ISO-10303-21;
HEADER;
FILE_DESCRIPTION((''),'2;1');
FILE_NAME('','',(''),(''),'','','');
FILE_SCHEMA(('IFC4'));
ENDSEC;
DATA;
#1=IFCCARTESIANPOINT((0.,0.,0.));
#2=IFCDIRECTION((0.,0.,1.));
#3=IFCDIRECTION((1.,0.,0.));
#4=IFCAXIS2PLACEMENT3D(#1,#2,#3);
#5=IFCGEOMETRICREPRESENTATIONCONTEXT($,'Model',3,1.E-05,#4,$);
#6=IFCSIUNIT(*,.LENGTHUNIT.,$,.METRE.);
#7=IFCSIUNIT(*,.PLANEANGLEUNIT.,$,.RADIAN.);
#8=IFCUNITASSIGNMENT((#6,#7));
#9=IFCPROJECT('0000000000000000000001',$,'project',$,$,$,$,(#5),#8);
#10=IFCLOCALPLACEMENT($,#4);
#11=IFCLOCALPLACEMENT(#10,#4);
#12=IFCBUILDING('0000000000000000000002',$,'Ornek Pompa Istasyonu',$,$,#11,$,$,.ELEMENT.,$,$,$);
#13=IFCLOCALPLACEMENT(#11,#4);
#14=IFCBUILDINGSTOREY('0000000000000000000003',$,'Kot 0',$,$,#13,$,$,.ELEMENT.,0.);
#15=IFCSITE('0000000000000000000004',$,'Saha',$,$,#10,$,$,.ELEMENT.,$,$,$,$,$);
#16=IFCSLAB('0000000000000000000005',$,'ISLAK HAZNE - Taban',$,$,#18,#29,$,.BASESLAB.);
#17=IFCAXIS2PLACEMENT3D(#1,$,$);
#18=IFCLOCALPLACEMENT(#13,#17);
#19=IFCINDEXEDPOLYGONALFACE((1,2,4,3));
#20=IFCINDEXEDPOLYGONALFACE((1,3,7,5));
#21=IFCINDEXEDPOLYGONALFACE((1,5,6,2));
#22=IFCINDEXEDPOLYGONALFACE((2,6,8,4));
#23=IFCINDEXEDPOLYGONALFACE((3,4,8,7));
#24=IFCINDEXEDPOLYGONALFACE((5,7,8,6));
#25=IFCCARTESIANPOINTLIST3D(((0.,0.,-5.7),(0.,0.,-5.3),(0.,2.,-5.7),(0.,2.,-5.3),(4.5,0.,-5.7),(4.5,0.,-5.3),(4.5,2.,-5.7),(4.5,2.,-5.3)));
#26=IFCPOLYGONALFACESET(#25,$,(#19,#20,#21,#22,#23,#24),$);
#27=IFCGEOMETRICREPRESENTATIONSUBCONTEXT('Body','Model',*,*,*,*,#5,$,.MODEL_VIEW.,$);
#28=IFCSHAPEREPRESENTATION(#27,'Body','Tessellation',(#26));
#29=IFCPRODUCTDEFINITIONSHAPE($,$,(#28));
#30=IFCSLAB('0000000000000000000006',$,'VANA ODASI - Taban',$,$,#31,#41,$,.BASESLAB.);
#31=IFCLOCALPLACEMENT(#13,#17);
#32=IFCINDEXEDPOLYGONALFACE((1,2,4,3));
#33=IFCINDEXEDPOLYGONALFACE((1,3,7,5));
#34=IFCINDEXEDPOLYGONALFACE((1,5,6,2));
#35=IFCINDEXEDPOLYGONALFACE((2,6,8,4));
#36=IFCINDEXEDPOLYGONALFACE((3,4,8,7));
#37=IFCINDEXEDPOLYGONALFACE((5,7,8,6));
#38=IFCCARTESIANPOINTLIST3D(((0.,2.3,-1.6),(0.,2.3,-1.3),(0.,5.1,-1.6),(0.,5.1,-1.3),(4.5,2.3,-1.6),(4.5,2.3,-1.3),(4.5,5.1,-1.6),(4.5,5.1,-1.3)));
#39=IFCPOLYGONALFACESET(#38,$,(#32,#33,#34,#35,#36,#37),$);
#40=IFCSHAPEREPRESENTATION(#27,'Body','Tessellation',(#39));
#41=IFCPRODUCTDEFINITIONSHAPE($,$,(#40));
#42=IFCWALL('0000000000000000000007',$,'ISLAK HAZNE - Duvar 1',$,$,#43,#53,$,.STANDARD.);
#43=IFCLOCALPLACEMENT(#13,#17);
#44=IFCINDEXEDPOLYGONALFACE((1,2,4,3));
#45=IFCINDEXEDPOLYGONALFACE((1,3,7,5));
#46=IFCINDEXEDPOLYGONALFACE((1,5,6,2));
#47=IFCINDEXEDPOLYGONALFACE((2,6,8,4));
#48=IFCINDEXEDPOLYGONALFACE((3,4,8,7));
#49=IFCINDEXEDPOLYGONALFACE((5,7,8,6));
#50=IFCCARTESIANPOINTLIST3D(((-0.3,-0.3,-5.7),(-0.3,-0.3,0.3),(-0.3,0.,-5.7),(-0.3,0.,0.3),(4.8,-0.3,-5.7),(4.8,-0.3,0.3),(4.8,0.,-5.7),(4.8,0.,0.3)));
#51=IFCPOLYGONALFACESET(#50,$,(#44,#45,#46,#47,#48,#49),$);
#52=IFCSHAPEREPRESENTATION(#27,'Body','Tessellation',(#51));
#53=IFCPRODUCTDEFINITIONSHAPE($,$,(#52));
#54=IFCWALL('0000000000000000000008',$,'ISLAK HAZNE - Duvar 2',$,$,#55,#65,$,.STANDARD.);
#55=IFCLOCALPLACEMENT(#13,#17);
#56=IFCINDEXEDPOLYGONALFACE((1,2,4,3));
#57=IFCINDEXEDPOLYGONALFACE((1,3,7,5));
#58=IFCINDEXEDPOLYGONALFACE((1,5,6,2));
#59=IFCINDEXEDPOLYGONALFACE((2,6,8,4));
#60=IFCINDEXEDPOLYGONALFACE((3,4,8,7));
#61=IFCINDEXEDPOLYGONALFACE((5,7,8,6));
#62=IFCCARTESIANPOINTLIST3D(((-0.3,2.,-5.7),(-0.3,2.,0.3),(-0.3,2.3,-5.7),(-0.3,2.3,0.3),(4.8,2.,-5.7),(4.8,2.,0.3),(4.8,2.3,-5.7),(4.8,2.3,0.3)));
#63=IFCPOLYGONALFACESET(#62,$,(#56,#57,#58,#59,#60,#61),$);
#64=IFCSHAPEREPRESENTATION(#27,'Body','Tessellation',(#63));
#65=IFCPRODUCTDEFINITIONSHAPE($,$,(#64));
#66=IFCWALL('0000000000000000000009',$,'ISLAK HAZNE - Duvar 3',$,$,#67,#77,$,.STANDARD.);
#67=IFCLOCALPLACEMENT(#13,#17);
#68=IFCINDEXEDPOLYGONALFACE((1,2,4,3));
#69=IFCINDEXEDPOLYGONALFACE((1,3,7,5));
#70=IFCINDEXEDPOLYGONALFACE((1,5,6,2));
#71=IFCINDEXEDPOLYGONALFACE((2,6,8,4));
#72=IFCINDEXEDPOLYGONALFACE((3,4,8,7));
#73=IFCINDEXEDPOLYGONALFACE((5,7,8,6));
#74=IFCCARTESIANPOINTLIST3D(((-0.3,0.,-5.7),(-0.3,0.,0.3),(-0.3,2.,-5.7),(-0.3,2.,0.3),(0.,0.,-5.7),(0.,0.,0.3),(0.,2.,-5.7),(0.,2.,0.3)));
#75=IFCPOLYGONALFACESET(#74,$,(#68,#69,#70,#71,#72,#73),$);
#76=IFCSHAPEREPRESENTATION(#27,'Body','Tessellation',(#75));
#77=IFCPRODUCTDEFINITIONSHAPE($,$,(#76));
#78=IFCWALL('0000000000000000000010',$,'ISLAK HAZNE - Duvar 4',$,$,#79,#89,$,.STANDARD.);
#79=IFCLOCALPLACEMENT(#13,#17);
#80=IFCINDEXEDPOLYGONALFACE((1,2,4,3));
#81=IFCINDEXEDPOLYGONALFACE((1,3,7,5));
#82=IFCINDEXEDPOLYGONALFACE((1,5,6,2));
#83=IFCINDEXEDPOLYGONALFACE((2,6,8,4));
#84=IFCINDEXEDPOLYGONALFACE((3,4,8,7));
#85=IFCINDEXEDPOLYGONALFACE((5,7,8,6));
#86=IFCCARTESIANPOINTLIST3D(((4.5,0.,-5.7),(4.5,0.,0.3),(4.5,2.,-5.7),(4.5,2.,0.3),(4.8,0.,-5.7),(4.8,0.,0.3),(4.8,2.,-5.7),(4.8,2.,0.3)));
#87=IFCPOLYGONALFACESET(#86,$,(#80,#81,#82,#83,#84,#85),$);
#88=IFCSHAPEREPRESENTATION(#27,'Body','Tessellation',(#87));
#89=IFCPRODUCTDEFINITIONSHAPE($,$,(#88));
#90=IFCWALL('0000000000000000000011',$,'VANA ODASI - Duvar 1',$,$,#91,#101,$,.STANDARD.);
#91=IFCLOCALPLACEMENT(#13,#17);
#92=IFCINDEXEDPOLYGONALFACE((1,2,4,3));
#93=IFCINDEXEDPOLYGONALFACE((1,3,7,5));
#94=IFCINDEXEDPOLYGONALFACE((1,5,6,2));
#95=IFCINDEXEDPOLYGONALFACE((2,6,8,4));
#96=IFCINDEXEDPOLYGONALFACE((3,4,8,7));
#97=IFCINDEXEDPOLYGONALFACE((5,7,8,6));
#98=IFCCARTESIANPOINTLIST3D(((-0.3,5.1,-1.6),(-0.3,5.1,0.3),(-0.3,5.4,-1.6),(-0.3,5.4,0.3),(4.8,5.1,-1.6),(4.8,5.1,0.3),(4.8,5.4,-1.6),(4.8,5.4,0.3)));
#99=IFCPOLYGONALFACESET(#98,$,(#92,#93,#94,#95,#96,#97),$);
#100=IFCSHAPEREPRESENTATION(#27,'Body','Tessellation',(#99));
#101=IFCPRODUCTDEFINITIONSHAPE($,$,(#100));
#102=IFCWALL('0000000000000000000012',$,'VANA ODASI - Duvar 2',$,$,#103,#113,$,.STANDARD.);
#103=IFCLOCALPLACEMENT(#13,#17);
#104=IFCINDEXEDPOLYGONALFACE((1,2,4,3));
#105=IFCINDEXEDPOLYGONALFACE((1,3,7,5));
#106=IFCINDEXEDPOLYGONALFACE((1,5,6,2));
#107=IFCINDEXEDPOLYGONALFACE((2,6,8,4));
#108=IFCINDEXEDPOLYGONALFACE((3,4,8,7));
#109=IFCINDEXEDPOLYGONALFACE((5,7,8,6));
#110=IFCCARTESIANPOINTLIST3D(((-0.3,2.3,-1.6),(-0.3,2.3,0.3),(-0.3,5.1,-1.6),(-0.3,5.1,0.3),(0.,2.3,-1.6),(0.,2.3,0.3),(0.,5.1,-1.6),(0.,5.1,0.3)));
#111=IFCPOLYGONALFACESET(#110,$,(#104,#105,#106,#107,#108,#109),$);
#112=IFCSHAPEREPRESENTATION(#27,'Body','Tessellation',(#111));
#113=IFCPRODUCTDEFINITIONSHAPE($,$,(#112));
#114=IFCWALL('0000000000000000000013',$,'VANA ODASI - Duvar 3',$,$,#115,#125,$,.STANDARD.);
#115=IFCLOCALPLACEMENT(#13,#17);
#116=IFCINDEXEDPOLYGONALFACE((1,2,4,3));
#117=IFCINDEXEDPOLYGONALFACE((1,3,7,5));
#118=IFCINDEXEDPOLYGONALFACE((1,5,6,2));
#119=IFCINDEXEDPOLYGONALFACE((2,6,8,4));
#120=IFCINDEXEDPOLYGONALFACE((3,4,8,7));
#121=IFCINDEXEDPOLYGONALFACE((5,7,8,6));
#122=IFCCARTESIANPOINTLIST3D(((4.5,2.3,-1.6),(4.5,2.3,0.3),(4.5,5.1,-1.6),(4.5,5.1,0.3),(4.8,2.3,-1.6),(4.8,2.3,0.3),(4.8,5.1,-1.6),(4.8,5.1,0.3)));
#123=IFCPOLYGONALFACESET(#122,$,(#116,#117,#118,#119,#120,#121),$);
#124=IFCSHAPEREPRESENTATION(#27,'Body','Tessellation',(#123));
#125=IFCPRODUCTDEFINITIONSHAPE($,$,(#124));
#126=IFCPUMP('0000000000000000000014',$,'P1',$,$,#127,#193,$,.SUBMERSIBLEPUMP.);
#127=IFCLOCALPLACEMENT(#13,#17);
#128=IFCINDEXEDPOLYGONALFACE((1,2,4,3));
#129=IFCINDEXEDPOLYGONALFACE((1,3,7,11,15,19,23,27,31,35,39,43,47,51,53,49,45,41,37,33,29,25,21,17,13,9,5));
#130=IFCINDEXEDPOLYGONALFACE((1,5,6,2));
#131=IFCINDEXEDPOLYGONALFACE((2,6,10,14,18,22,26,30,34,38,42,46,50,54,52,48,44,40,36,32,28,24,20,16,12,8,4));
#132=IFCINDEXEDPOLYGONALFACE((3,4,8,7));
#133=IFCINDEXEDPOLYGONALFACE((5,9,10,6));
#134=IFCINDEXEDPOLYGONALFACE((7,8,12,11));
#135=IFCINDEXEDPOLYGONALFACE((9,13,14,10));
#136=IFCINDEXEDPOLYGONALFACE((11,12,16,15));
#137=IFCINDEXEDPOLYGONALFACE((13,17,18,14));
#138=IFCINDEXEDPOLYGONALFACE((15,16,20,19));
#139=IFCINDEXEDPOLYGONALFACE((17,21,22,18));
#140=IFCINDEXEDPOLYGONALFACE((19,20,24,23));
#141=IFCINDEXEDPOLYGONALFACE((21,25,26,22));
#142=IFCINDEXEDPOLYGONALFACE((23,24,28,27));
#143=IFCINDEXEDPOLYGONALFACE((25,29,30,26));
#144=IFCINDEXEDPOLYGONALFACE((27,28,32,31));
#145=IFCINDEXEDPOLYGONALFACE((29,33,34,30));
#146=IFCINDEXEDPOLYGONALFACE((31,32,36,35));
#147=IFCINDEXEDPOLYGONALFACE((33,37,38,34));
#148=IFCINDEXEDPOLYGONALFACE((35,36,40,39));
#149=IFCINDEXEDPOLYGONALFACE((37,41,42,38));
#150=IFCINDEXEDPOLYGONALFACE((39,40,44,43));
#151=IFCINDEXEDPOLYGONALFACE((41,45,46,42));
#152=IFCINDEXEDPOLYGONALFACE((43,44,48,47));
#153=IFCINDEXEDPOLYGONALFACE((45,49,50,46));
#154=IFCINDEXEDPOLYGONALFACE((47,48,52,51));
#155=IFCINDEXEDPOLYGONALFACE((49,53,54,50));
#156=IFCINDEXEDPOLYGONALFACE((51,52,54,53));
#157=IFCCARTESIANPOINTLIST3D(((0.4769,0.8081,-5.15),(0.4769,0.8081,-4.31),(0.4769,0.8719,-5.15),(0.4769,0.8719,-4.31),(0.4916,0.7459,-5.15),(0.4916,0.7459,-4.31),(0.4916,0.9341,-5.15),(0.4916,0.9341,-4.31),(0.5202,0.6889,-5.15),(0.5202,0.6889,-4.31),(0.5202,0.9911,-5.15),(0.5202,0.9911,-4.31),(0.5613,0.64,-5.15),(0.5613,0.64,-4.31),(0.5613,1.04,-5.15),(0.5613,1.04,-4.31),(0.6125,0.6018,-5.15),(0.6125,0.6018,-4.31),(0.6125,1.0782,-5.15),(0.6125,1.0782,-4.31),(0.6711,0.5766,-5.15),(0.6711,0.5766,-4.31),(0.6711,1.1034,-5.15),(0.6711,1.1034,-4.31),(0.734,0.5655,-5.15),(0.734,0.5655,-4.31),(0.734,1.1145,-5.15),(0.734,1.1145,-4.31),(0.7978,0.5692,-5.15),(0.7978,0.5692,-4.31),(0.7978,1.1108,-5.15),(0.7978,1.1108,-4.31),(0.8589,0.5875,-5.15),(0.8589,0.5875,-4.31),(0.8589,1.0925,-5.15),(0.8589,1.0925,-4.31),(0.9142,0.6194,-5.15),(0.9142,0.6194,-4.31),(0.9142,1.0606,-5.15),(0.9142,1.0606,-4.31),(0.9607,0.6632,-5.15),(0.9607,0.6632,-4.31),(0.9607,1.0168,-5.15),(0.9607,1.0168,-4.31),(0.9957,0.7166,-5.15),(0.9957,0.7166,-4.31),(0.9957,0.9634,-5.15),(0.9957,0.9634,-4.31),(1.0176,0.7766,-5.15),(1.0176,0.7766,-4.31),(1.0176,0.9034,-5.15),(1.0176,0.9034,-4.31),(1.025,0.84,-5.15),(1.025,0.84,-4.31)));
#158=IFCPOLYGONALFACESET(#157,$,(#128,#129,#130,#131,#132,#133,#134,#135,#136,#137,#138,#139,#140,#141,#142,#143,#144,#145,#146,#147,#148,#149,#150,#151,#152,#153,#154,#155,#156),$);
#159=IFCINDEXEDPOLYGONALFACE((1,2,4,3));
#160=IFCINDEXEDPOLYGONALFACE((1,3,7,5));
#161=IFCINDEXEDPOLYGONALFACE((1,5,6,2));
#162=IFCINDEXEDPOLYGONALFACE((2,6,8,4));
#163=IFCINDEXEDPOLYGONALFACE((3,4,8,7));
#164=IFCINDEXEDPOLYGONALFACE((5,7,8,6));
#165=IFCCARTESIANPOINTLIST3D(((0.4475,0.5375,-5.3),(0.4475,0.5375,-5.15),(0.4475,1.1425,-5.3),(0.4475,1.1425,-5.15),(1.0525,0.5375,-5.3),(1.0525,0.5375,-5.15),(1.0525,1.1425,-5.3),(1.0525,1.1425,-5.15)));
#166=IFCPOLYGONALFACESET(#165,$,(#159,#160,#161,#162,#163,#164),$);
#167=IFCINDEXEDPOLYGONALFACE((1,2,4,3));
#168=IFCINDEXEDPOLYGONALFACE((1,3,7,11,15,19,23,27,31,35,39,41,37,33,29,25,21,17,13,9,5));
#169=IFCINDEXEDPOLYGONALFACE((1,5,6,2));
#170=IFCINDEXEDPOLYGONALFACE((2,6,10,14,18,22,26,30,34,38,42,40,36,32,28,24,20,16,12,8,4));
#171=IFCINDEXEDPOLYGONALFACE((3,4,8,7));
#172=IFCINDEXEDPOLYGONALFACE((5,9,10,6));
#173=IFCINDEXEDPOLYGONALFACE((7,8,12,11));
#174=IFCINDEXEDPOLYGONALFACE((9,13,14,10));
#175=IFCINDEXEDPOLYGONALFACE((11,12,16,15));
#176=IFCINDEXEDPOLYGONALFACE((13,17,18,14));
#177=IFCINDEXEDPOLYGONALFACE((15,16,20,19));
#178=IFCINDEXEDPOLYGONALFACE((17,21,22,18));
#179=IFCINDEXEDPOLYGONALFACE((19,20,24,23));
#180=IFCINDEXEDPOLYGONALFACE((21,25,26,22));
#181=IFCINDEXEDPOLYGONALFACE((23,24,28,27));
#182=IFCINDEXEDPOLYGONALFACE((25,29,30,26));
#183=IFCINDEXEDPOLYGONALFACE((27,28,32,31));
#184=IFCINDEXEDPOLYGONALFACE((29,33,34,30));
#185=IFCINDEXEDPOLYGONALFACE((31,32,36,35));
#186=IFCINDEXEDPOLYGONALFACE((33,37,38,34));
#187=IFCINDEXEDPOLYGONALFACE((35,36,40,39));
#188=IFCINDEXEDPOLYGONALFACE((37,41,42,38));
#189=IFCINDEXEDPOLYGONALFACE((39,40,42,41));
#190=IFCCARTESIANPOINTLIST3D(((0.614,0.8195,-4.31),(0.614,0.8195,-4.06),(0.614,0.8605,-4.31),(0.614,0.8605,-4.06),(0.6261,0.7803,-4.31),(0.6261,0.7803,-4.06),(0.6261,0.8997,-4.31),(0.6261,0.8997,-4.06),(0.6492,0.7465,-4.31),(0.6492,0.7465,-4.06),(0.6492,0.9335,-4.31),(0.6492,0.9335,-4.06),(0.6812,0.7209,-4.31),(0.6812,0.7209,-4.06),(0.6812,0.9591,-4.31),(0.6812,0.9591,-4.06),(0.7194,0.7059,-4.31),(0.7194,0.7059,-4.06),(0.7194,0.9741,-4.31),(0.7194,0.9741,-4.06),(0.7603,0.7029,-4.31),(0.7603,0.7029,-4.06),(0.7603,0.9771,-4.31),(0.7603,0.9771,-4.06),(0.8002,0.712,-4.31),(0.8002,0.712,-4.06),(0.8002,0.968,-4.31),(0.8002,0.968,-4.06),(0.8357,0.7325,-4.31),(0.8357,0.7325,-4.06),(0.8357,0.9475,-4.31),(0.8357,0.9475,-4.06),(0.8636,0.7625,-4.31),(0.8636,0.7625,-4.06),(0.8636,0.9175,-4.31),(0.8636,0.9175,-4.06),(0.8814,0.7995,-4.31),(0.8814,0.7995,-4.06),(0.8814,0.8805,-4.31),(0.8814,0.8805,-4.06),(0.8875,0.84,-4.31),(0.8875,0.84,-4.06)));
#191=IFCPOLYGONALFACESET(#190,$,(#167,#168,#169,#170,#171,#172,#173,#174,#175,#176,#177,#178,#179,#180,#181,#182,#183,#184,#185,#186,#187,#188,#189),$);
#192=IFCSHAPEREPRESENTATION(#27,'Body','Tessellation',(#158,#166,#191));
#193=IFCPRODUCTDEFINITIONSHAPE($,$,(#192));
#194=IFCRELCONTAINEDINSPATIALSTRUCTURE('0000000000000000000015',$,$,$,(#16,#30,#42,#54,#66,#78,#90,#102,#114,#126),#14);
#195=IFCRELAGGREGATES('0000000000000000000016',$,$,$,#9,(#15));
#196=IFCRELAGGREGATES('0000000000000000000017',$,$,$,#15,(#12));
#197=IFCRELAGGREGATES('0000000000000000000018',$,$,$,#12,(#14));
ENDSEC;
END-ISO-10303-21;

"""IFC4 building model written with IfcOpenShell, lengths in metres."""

from ifc_helpers import new_model, si_unit, frame, origin_with_axes, origin_2d, place, context, subcontext, project, spatial, polyline, circle, outline, extrude, element, save


model = new_model("IFC4")

# Units and contexts
model_context = context("Model", 3, precision=1e-05, world=origin_with_axes())
body_context = subcontext(model_context, "Body", "Model", "MODEL_VIEW")
ifc_project = project(units=[si_unit("LENGTHUNIT", "METRE"), si_unit("PLANEANGLEUNIT", "RADIAN")], contexts=[model_context])

# Site, building, storey
site_placement = place(None, origin_with_axes())
site = spatial("IfcSite", under=ifc_project, at=site_placement, Name="Saha", CompositionType="ELEMENT")
building_placement = place(site_placement, origin_with_axes())
building = spatial("IfcBuilding", under=site, at=building_placement, Name="Ornek Pompa Istasyonu", CompositionType="ELEMENT")
storey_placement = place(building_placement, origin_with_axes())
storey = spatial("IfcBuildingStorey", under=building, at=storey_placement, Name="Kot 0", CompositionType="ELEMENT", Elevation=0.0)

# Slabs
slab_1_placement = place(storey_placement, origin_with_axes())
element("IfcSlab", 1, at=slab_1_placement, inside=storey, Name="ISLAK HAZNE - Taban", PredefinedType="BASESLAB", context=body_context, shape_type="SweptSolid", body=[
    extrude(outline(polyline([(0.0, 0.0), (4.5, 0.0), (4.5, 2.0), (0.0, 2.0), (0.0, 0.0)])), frame((0.0, 0.0, -5.7), z_axis=(0.0, 0.0, 1.0), x_axis=(1.0, 0.0, 0.0)), (0.0, 0.0, 1.0), 0.4),
])
slab_2_placement = place(storey_placement, origin_with_axes())
element("IfcSlab", 2, at=slab_2_placement, inside=storey, Name="VANA ODASI - Taban", PredefinedType="BASESLAB", context=body_context, shape_type="SweptSolid", body=[
    extrude(outline(polyline([(0.0, 0.0), (4.5, 0.0), (4.5, 2.8), (0.0, 2.8), (0.0, 0.0)])), frame((0.0, 2.3, -1.6), z_axis=(0.0, 0.0, 1.0), x_axis=(1.0, 0.0, 0.0)), (0.0, 0.0, 1.0), 0.3),
])

# Walls
wall_1_placement = place(storey_placement, origin_with_axes())
element("IfcWall", 3, at=wall_1_placement, inside=storey, Name="ISLAK HAZNE - Duvar 1", PredefinedType="STANDARD", context=body_context, shape_type="SweptSolid", body=[
    extrude(outline(polyline([(0.0, 0.0), (5.1, 0.0), (5.1, 0.3), (0.0, 0.3), (0.0, 0.0)])), frame((-0.3, -0.3, -5.7), z_axis=(0.0, 0.0, 1.0), x_axis=(1.0, 0.0, 0.0)), (0.0, 0.0, 1.0), 6.0),
])
wall_2_placement = place(storey_placement, origin_with_axes())
element("IfcWall", 4, at=wall_2_placement, inside=storey, Name="ISLAK HAZNE - Duvar 2", PredefinedType="STANDARD", context=body_context, shape_type="SweptSolid", body=[
    extrude(outline(polyline([(0.0, 0.0), (5.1, 0.0), (5.1, 0.3), (0.0, 0.3), (0.0, 0.0)])), frame((-0.3, 2.0, -5.7), z_axis=(0.0, 0.0, 1.0), x_axis=(1.0, 0.0, 0.0)), (0.0, 0.0, 1.0), 6.0),
])
wall_3_placement = place(storey_placement, origin_with_axes())
element("IfcWall", 5, at=wall_3_placement, inside=storey, Name="ISLAK HAZNE - Duvar 3", PredefinedType="STANDARD", context=body_context, shape_type="SweptSolid", body=[
    extrude(outline(polyline([(0.0, 0.0), (0.3, 0.0), (0.3, 2.0), (0.0, 2.0), (0.0, 0.0)])), frame((-0.3, 0.0, -5.7), z_axis=(0.0, 0.0, 1.0), x_axis=(1.0, 0.0, 0.0)), (0.0, 0.0, 1.0), 6.0),
])
wall_4_placement = place(storey_placement, origin_with_axes())
element("IfcWall", 6, at=wall_4_placement, inside=storey, Name="ISLAK HAZNE - Duvar 4", PredefinedType="STANDARD", context=body_context, shape_type="SweptSolid", body=[
    extrude(outline(polyline([(0.0, 0.0), (0.3, 0.0), (0.3, 2.0), (0.0, 2.0), (0.0, 0.0)])), frame((4.5, 0.0, -5.7), z_axis=(0.0, 0.0, 1.0), x_axis=(1.0, 0.0, 0.0)), (0.0, 0.0, 1.0), 6.0),
])
wall_5_placement = place(storey_placement, origin_with_axes())
element("IfcWall", 7, at=wall_5_placement, inside=storey, Name="VANA ODASI - Duvar 1", PredefinedType="STANDARD", context=body_context, shape_type="SweptSolid", body=[
    extrude(outline(polyline([(0.0, 0.0), (5.1, 0.0), (5.1, 0.3), (0.0, 0.3), (0.0, 0.0)])), frame((-0.3, 5.1, -1.6), z_axis=(0.0, 0.0, 1.0), x_axis=(1.0, 0.0, 0.0)), (0.0, 0.0, 1.0), 1.9),
])
wall_6_placement = place(storey_placement, origin_with_axes())
element("IfcWall", 8, at=wall_6_placement, inside=storey, Name="VANA ODASI - Duvar 2", PredefinedType="STANDARD", context=body_context, shape_type="SweptSolid", body=[
    extrude(outline(polyline([(0.0, 0.0), (0.3, 0.0), (0.3, 2.8), (0.0, 2.8), (0.0, 0.0)])), frame((-0.3, 2.3, -1.6), z_axis=(0.0, 0.0, 1.0), x_axis=(1.0, 0.0, 0.0)), (0.0, 0.0, 1.0), 1.9),
])
wall_7_placement = place(storey_placement, origin_with_axes())
element("IfcWall", 9, at=wall_7_placement, inside=storey, Name="VANA ODASI - Duvar 3", PredefinedType="STANDARD", context=body_context, shape_type="SweptSolid", body=[
    extrude(outline(polyline([(0.0, 0.0), (0.3, 0.0), (0.3, 2.8), (0.0, 2.8), (0.0, 0.0)])), frame((4.5, 2.3, -1.6), z_axis=(0.0, 0.0, 1.0), x_axis=(1.0, 0.0, 0.0)), (0.0, 0.0, 1.0), 1.9),
])

# Pump
pump_1_placement = place(storey_placement, origin_with_axes())
element("IfcPump", 10, at=pump_1_placement, inside=storey, Name="P1", PredefinedType="SUBMERSIBLEPUMP", context=body_context, shape_type="SweptSolid", body=[
    extrude(circle(Radius=0.275, at=origin_2d()), frame((0.75, 0.84, -5.15), z_axis=(0.0, 0.0, 1.0), x_axis=(1.0, 0.0, 0.0)), (0.0, 0.0, 1.0), 0.84),
    extrude(outline(polyline([(0.0, 0.0), (0.605, 0.0), (0.605, 0.605), (0.0, 0.605), (0.0, 0.0)])), frame((1.0525, 0.5375, -5.3), z_axis=(0.0, 0.0, 1.0), x_axis=(0.0, 1.0, 0.0)), (0.0, 0.0, 1.0), 0.15),
    extrude(circle(Radius=0.1375, at=origin_2d()), frame((0.75, 0.84, -4.31), z_axis=(0.0, 0.0, 1.0), x_axis=(1.0, 0.0, 0.0)), (0.0, 0.0, 1.0), 0.25),
])

save(model, "model.ifc")
